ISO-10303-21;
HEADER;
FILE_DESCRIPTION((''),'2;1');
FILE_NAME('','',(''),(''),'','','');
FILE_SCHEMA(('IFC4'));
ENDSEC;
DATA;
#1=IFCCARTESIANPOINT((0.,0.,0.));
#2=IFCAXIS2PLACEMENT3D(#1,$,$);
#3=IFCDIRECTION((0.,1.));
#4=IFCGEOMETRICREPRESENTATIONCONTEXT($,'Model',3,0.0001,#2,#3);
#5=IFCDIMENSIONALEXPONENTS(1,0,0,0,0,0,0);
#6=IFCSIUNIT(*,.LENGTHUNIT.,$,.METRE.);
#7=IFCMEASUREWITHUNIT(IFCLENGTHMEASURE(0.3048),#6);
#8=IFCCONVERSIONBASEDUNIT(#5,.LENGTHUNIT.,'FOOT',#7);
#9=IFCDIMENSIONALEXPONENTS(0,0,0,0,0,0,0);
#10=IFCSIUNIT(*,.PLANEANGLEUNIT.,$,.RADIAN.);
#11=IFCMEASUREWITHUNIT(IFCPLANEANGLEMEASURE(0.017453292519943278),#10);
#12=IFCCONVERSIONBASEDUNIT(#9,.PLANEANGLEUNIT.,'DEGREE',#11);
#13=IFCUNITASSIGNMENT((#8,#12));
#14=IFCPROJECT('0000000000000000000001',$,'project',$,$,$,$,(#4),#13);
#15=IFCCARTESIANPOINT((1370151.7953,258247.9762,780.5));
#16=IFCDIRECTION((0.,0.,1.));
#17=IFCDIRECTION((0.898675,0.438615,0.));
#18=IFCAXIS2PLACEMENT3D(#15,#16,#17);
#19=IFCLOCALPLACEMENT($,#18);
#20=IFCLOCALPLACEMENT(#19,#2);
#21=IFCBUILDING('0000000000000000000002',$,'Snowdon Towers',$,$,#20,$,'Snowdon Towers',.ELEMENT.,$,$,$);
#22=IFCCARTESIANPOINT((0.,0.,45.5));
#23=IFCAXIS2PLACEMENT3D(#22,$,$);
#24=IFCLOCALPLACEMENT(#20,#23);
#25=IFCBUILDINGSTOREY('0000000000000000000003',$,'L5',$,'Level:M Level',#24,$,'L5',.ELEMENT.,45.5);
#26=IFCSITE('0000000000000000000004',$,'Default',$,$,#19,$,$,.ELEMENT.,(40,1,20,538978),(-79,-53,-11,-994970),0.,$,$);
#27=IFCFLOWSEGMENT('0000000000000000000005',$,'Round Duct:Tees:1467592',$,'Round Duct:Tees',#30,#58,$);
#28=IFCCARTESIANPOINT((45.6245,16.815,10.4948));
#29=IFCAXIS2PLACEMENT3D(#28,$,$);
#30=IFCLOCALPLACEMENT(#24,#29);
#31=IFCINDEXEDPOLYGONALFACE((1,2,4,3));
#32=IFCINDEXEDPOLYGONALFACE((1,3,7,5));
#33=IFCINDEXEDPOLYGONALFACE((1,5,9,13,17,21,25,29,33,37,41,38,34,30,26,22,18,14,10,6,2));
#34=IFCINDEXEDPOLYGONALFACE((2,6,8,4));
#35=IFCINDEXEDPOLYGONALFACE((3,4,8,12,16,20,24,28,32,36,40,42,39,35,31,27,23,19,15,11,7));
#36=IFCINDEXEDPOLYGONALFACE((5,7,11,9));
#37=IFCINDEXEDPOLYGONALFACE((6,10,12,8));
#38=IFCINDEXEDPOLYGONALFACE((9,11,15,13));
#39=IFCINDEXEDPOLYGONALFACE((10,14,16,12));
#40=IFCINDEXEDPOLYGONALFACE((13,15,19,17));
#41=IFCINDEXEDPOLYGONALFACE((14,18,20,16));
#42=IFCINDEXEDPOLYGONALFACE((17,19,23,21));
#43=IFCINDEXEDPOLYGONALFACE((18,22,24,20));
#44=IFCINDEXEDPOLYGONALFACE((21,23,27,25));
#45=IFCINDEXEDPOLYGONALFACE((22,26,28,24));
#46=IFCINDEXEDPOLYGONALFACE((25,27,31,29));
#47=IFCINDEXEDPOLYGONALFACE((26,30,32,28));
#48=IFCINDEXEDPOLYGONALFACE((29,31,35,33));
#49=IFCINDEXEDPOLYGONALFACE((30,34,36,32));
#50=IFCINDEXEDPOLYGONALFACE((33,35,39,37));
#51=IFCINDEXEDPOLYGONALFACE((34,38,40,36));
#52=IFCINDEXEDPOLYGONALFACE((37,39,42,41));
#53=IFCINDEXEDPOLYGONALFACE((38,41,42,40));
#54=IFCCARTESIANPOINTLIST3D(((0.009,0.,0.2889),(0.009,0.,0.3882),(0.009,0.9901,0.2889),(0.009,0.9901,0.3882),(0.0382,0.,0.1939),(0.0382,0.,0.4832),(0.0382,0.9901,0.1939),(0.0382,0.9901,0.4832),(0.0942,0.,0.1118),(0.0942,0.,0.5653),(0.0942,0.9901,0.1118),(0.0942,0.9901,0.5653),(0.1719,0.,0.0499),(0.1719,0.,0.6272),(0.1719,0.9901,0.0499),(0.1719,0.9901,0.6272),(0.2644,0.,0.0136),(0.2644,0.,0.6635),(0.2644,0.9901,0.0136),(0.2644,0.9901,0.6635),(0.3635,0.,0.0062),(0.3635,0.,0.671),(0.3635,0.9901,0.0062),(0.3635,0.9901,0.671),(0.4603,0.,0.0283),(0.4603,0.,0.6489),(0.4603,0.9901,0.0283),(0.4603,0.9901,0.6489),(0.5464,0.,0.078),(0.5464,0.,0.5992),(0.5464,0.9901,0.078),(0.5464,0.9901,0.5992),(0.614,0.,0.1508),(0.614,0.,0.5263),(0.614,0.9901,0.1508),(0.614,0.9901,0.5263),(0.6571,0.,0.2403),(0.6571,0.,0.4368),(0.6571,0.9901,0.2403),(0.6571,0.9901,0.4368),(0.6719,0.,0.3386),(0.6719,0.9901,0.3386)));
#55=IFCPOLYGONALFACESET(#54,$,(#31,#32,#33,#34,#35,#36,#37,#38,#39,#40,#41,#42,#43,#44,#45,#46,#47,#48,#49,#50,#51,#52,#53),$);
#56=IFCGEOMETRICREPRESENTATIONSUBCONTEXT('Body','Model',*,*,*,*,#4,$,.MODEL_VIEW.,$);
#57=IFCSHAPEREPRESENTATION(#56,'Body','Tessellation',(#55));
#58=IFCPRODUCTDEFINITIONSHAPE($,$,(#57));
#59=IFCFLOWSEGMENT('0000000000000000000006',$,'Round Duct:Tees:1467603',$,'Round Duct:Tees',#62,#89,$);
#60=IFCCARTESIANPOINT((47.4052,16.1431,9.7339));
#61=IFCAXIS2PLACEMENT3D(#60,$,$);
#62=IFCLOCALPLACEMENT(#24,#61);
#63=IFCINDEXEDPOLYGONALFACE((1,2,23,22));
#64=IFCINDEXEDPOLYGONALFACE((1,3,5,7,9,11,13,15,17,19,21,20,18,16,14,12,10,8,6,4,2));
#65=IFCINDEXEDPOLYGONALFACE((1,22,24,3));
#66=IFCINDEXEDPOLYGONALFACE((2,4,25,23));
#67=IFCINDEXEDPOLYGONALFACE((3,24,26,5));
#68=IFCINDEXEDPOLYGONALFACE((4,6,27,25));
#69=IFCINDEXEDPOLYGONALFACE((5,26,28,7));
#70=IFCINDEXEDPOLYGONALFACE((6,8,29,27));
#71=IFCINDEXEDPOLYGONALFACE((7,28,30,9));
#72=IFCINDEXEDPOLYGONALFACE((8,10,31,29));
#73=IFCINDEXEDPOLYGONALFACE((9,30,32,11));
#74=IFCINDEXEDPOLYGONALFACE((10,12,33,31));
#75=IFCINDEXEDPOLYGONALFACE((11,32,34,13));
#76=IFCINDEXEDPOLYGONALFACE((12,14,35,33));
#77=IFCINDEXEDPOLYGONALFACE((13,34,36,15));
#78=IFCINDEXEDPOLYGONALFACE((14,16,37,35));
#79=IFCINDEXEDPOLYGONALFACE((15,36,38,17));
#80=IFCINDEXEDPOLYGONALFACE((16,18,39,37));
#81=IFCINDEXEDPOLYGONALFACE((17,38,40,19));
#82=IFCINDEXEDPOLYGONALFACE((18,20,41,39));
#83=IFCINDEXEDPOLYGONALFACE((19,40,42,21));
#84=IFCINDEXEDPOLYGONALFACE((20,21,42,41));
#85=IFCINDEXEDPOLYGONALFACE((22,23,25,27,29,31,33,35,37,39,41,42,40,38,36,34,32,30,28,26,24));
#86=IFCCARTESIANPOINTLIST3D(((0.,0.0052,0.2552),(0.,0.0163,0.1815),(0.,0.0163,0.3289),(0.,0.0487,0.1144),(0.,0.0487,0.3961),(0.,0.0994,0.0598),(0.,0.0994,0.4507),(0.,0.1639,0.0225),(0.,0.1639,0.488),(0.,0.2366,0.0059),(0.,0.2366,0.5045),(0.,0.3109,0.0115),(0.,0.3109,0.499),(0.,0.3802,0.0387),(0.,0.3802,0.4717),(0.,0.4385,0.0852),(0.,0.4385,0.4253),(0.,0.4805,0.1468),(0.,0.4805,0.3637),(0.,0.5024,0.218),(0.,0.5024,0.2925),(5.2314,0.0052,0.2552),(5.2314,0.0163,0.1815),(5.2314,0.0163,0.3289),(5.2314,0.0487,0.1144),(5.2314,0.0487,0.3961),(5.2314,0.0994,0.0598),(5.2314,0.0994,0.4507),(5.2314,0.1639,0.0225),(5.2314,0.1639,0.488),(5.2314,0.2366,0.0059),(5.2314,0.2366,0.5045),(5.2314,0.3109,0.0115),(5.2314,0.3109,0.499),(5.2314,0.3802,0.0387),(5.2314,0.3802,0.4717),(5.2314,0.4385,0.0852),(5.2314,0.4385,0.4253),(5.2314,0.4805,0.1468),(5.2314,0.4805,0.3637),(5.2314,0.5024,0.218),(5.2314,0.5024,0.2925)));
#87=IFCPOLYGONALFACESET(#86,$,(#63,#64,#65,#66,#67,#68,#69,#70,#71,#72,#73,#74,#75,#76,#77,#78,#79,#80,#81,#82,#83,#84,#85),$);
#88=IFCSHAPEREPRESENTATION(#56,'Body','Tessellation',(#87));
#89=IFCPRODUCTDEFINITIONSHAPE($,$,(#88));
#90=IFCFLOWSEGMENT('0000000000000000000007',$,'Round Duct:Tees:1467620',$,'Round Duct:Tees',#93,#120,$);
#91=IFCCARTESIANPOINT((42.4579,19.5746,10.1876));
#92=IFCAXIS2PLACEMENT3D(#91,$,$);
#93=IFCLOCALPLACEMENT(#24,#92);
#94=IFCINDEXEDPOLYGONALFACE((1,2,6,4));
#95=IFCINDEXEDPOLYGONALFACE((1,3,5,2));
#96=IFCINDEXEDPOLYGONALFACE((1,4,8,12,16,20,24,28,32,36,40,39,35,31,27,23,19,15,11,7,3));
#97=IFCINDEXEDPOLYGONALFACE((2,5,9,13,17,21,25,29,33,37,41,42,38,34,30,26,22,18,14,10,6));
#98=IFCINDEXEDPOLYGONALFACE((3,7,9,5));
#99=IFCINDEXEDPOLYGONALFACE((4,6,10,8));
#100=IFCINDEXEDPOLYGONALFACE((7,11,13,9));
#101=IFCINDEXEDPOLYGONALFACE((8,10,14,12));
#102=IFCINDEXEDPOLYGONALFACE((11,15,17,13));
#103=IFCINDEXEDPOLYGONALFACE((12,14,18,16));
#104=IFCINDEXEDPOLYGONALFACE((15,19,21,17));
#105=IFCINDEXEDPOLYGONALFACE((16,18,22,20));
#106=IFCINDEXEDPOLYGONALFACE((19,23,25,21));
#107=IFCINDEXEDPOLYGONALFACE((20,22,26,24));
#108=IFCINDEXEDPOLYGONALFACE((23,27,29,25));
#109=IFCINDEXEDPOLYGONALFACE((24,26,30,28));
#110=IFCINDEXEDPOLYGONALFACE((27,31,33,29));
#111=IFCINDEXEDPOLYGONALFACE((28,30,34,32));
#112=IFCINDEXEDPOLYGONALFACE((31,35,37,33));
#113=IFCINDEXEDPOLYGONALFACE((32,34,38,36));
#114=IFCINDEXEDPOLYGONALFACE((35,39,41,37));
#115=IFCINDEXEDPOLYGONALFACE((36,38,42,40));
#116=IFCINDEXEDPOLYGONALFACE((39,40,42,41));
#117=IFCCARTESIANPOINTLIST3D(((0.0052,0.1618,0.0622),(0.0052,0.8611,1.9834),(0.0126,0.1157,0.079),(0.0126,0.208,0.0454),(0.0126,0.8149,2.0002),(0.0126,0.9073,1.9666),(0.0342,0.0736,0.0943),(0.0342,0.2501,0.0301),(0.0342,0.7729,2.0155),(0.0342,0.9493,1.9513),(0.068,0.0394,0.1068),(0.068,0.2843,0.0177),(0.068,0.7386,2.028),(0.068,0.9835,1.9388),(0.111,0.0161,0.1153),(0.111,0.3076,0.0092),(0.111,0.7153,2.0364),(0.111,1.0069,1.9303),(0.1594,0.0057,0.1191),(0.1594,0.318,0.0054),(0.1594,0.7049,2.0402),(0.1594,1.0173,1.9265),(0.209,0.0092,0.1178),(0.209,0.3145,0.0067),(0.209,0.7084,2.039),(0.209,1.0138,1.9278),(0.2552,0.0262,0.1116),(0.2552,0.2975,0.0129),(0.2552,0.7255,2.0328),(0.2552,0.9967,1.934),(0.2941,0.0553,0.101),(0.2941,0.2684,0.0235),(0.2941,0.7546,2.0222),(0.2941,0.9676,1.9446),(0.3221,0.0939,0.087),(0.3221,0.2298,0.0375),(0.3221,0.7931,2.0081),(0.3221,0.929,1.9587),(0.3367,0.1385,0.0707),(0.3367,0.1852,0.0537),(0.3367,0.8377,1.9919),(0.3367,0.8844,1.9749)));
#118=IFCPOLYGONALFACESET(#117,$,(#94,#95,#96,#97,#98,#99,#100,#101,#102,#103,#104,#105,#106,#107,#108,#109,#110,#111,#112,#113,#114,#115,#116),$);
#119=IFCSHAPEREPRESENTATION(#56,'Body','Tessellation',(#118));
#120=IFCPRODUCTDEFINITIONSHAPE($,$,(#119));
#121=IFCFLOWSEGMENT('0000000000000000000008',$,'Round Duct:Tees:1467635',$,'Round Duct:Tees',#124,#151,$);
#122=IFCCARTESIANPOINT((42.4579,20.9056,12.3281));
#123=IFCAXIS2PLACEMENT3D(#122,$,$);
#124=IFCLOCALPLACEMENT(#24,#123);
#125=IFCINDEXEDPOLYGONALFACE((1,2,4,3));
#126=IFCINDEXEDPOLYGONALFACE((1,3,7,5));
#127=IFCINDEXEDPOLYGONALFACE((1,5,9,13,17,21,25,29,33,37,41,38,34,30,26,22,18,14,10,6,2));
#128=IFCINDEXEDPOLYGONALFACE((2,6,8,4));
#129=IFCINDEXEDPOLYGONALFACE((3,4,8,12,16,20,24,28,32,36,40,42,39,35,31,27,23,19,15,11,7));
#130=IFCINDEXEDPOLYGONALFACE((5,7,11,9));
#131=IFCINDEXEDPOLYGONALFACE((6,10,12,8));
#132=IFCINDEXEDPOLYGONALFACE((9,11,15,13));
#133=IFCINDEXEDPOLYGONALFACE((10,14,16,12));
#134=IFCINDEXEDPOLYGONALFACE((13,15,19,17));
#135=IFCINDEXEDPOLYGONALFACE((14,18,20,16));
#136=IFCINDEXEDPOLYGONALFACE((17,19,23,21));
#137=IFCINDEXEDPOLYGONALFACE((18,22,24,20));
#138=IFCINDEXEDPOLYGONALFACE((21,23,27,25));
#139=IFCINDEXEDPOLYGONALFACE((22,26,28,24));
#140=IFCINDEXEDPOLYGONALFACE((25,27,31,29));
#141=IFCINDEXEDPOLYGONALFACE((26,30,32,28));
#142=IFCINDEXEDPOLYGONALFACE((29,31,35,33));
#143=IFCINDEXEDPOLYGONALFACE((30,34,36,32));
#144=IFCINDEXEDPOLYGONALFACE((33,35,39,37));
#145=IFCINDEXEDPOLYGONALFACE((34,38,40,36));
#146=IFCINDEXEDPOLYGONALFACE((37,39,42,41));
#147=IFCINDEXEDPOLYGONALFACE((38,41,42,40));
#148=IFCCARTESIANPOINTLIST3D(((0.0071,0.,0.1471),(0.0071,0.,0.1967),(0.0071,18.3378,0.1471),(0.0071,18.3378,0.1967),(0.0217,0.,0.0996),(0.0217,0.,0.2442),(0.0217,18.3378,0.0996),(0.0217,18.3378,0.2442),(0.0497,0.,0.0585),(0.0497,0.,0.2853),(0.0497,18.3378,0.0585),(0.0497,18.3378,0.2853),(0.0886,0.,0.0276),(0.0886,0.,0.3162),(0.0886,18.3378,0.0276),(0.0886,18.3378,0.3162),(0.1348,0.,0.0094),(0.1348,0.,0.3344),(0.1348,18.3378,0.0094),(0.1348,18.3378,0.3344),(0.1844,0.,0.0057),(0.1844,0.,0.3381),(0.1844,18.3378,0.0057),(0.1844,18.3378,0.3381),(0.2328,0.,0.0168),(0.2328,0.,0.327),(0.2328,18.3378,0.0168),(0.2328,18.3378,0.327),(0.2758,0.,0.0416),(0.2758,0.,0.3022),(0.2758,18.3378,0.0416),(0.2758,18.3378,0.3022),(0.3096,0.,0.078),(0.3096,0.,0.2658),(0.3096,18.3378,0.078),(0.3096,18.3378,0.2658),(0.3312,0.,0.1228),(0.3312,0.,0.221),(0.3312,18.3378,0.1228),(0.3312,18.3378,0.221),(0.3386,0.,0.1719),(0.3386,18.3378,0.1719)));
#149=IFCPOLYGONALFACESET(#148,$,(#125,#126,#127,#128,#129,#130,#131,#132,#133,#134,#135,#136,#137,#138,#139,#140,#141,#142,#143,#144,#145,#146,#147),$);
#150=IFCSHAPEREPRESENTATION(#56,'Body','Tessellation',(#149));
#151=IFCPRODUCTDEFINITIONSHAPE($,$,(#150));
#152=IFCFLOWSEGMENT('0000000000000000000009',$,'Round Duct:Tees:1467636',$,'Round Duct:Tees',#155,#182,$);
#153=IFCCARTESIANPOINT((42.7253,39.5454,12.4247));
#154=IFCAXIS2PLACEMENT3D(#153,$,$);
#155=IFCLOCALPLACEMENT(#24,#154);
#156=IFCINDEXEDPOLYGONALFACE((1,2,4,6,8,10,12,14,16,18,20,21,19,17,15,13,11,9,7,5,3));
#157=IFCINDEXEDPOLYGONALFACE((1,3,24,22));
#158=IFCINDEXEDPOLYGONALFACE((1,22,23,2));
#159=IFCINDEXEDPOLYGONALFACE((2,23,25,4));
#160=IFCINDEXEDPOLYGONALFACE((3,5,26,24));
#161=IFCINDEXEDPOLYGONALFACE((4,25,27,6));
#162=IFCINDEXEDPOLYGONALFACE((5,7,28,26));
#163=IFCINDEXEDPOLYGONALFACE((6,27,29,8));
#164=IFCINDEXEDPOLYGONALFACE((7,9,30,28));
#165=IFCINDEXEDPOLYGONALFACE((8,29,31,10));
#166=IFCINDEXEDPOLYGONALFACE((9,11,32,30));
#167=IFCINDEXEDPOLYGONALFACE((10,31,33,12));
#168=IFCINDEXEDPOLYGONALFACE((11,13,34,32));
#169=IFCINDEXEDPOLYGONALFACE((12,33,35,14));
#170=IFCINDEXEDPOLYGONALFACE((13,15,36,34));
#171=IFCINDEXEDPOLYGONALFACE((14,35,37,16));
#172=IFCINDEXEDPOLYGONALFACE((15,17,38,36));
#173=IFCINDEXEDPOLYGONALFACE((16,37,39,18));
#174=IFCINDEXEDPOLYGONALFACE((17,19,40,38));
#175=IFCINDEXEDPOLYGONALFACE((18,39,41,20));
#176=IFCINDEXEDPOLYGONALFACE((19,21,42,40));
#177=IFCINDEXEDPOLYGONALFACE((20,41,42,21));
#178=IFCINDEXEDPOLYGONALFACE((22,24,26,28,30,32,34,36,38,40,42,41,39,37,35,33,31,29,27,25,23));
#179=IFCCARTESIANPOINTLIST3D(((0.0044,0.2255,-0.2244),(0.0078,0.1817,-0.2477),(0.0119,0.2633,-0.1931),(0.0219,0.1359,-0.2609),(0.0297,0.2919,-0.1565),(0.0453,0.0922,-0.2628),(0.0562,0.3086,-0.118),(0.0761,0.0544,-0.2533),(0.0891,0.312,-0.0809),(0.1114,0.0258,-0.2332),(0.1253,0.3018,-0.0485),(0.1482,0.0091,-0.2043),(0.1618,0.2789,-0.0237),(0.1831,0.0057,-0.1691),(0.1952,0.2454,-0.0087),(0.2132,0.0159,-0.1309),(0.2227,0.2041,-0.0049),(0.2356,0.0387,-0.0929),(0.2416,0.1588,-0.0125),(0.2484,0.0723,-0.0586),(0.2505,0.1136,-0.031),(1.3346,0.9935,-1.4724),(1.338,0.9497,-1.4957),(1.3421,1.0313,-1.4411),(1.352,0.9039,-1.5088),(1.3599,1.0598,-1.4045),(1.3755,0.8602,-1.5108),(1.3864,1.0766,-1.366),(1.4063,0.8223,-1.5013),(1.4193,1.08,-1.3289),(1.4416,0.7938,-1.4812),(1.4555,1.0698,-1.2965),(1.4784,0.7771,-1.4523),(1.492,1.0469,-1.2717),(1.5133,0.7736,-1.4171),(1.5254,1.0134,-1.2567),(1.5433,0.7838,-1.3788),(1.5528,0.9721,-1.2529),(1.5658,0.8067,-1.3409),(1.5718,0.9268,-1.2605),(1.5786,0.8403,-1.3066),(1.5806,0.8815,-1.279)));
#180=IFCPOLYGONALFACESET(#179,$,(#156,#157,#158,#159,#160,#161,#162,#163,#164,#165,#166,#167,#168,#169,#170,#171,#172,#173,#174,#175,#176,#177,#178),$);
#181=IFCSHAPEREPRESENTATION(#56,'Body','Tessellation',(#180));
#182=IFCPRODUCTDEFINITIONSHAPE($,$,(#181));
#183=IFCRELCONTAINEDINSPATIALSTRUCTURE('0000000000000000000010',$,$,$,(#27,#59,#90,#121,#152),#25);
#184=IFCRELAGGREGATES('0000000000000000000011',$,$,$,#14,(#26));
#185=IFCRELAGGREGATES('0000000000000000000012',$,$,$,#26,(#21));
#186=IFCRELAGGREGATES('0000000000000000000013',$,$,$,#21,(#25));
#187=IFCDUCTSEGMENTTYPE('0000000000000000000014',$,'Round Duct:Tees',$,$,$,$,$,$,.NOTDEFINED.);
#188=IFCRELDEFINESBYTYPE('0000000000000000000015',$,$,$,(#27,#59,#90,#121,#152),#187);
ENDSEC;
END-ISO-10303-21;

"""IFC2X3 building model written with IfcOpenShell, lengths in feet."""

from ifc_helpers import new_model, entity, si_unit, converted_unit, direction, frame, frame_2d, origin, place, context, subcontext, project, spatial, circle, extrude, type_object, element, save


model = new_model("IFC2X3")

# Units and contexts
model_context = context("Model", 3, precision=0.0001, world=origin(), true_north=direction((0.0, 1.0)))
body_context = subcontext(model_context, "Body", "Model", "MODEL_VIEW")
ifc_project = project(units=[converted_unit("LENGTHUNIT", "FOOT", entity("IfcLengthMeasure", 0.3048), si_unit("LENGTHUNIT", "METRE"), dimensions=[1, 0, 0, 0, 0, 0, 0]), converted_unit("PLANEANGLEUNIT", "DEGREE", entity("IfcPlaneAngleMeasure", 0.017453292519943278), si_unit("PLANEANGLEUNIT", "RADIAN"), dimensions=[0, 0, 0, 0, 0, 0, 0])], contexts=[model_context])

# Site, building, storey
site_placement = place(None, frame((1370151.7953, 258247.9762, 780.5), z_axis=(0.0, 0.0, 1.0), x_axis=(0.898675, 0.438615, 0.0)))
site = spatial("IfcSite", under=ifc_project, at=site_placement, Name="Default", CompositionType="ELEMENT", RefLatitude=(40, 1, 20, 538978), RefLongitude=(-79, -53, -11, -994970), RefElevation=0.0)
building_placement = place(site_placement, origin())
building = spatial("IfcBuilding", under=site, at=building_placement, Name="Snowdon Towers", LongName="Snowdon Towers", CompositionType="ELEMENT")
storey_placement = place(building_placement, frame((0.0, 0.0, 45.5)))
storey = spatial("IfcBuildingStorey", under=building, at=storey_placement, Name="L5", ObjectType="Level:M Level", LongName="L5", CompositionType="ELEMENT", Elevation=45.5)

# Flow segments
duct_segment_type = type_object("IfcDuctSegmentType", Name="Round Duct:Tees", PredefinedType="NOTDEFINED")
flow_segment_1_placement = place(storey_placement, frame((45.6245, 16.815, 10.4948)))
element("IfcFlowSegment", 1, at=flow_segment_1_placement, inside=storey, type_object=duct_segment_type, Name="Round Duct:Tees:1467592", ObjectType="Round Duct:Tees", context=body_context, shape_type="SweptSolid", body=[
    extrude(circle(Radius=0.3333, at=frame_2d((0.0, 0.0), x_axis=(1.0, 0.0))), frame((0.3386, 0.0, 0.3386), z_axis=(0.0, 1.0, 0.0), x_axis=(1.0, 0.0, 0.0)), (0.0, 0.0, 1.0), 0.9901),
])
flow_segment_2_placement = place(storey_placement, frame((47.4052, 16.1431, 9.7339)))
element("IfcFlowSegment", 2, at=flow_segment_2_placement, inside=storey, type_object=duct_segment_type, Name="Round Duct:Tees:1467603", ObjectType="Round Duct:Tees", context=body_context, shape_type="SweptSolid", body=[
    extrude(circle(Radius=0.25, at=frame_2d((0.0, 0.0), x_axis=(1.0, 0.0))), frame((0.0, 0.2552, 0.2552), z_axis=(1.0, 0.0, 0.0), x_axis=(0.0, -1.0, 0.0)), (0.0, 0.0, 1.0), 5.2314),
])
flow_segment_3_placement = place(storey_placement, frame((42.4579, 19.5746, 10.1876)))
element("IfcFlowSegment", 3, at=flow_segment_3_placement, inside=storey, type_object=duct_segment_type, Name="Round Duct:Tees:1467620", ObjectType="Round Duct:Tees", context=body_context, shape_type="SweptSolid", body=[
    extrude(circle(Radius=0.1667, at=frame_2d((0.0, 0.0), x_axis=(1.0, 0.0))), frame((0.1719, 0.1618, 0.0622), z_axis=(0.0, 0.34202, 0.939693), x_axis=(-1.0, 0.0, 0.0)), (0.0, 0.0, 1.0), 2.0444),
])
flow_segment_4_placement = place(storey_placement, frame((42.4579, 20.9056, 12.3281)))
element("IfcFlowSegment", 4, at=flow_segment_4_placement, inside=storey, type_object=duct_segment_type, Name="Round Duct:Tees:1467635", ObjectType="Round Duct:Tees", context=body_context, shape_type="SweptSolid", body=[
    extrude(circle(Radius=0.1667, at=frame_2d((0.0, 0.0), x_axis=(1.0, 0.0))), frame((0.1719, 0.0, 0.1719), z_axis=(0.0, 1.0, 0.0), x_axis=(1.0, 0.0, 0.0)), (0.0, 0.0, 1.0), 18.3378),
])
flow_segment_5_placement = place(storey_placement, frame((42.7253, 39.5454, 12.4247)))
element("IfcFlowSegment", 5, at=flow_segment_5_placement, inside=storey, type_object=duct_segment_type, Name="Round Duct:Tees:1467636", ObjectType="Round Duct:Tees", context=body_context, shape_type="SweptSolid", body=[
    extrude(circle(Radius=0.1667, at=frame_2d((0.0, 0.0), x_axis=(1.0, 0.0))), frame((1.4578, 0.9268, -1.3821), z_axis=(-0.672135, -0.388057, 0.630592), x_axis=(0.68421, 0.0, 0.729285)), (0.0, 0.0, 1.0), 1.979),
])

save(model, "model.ifc")
